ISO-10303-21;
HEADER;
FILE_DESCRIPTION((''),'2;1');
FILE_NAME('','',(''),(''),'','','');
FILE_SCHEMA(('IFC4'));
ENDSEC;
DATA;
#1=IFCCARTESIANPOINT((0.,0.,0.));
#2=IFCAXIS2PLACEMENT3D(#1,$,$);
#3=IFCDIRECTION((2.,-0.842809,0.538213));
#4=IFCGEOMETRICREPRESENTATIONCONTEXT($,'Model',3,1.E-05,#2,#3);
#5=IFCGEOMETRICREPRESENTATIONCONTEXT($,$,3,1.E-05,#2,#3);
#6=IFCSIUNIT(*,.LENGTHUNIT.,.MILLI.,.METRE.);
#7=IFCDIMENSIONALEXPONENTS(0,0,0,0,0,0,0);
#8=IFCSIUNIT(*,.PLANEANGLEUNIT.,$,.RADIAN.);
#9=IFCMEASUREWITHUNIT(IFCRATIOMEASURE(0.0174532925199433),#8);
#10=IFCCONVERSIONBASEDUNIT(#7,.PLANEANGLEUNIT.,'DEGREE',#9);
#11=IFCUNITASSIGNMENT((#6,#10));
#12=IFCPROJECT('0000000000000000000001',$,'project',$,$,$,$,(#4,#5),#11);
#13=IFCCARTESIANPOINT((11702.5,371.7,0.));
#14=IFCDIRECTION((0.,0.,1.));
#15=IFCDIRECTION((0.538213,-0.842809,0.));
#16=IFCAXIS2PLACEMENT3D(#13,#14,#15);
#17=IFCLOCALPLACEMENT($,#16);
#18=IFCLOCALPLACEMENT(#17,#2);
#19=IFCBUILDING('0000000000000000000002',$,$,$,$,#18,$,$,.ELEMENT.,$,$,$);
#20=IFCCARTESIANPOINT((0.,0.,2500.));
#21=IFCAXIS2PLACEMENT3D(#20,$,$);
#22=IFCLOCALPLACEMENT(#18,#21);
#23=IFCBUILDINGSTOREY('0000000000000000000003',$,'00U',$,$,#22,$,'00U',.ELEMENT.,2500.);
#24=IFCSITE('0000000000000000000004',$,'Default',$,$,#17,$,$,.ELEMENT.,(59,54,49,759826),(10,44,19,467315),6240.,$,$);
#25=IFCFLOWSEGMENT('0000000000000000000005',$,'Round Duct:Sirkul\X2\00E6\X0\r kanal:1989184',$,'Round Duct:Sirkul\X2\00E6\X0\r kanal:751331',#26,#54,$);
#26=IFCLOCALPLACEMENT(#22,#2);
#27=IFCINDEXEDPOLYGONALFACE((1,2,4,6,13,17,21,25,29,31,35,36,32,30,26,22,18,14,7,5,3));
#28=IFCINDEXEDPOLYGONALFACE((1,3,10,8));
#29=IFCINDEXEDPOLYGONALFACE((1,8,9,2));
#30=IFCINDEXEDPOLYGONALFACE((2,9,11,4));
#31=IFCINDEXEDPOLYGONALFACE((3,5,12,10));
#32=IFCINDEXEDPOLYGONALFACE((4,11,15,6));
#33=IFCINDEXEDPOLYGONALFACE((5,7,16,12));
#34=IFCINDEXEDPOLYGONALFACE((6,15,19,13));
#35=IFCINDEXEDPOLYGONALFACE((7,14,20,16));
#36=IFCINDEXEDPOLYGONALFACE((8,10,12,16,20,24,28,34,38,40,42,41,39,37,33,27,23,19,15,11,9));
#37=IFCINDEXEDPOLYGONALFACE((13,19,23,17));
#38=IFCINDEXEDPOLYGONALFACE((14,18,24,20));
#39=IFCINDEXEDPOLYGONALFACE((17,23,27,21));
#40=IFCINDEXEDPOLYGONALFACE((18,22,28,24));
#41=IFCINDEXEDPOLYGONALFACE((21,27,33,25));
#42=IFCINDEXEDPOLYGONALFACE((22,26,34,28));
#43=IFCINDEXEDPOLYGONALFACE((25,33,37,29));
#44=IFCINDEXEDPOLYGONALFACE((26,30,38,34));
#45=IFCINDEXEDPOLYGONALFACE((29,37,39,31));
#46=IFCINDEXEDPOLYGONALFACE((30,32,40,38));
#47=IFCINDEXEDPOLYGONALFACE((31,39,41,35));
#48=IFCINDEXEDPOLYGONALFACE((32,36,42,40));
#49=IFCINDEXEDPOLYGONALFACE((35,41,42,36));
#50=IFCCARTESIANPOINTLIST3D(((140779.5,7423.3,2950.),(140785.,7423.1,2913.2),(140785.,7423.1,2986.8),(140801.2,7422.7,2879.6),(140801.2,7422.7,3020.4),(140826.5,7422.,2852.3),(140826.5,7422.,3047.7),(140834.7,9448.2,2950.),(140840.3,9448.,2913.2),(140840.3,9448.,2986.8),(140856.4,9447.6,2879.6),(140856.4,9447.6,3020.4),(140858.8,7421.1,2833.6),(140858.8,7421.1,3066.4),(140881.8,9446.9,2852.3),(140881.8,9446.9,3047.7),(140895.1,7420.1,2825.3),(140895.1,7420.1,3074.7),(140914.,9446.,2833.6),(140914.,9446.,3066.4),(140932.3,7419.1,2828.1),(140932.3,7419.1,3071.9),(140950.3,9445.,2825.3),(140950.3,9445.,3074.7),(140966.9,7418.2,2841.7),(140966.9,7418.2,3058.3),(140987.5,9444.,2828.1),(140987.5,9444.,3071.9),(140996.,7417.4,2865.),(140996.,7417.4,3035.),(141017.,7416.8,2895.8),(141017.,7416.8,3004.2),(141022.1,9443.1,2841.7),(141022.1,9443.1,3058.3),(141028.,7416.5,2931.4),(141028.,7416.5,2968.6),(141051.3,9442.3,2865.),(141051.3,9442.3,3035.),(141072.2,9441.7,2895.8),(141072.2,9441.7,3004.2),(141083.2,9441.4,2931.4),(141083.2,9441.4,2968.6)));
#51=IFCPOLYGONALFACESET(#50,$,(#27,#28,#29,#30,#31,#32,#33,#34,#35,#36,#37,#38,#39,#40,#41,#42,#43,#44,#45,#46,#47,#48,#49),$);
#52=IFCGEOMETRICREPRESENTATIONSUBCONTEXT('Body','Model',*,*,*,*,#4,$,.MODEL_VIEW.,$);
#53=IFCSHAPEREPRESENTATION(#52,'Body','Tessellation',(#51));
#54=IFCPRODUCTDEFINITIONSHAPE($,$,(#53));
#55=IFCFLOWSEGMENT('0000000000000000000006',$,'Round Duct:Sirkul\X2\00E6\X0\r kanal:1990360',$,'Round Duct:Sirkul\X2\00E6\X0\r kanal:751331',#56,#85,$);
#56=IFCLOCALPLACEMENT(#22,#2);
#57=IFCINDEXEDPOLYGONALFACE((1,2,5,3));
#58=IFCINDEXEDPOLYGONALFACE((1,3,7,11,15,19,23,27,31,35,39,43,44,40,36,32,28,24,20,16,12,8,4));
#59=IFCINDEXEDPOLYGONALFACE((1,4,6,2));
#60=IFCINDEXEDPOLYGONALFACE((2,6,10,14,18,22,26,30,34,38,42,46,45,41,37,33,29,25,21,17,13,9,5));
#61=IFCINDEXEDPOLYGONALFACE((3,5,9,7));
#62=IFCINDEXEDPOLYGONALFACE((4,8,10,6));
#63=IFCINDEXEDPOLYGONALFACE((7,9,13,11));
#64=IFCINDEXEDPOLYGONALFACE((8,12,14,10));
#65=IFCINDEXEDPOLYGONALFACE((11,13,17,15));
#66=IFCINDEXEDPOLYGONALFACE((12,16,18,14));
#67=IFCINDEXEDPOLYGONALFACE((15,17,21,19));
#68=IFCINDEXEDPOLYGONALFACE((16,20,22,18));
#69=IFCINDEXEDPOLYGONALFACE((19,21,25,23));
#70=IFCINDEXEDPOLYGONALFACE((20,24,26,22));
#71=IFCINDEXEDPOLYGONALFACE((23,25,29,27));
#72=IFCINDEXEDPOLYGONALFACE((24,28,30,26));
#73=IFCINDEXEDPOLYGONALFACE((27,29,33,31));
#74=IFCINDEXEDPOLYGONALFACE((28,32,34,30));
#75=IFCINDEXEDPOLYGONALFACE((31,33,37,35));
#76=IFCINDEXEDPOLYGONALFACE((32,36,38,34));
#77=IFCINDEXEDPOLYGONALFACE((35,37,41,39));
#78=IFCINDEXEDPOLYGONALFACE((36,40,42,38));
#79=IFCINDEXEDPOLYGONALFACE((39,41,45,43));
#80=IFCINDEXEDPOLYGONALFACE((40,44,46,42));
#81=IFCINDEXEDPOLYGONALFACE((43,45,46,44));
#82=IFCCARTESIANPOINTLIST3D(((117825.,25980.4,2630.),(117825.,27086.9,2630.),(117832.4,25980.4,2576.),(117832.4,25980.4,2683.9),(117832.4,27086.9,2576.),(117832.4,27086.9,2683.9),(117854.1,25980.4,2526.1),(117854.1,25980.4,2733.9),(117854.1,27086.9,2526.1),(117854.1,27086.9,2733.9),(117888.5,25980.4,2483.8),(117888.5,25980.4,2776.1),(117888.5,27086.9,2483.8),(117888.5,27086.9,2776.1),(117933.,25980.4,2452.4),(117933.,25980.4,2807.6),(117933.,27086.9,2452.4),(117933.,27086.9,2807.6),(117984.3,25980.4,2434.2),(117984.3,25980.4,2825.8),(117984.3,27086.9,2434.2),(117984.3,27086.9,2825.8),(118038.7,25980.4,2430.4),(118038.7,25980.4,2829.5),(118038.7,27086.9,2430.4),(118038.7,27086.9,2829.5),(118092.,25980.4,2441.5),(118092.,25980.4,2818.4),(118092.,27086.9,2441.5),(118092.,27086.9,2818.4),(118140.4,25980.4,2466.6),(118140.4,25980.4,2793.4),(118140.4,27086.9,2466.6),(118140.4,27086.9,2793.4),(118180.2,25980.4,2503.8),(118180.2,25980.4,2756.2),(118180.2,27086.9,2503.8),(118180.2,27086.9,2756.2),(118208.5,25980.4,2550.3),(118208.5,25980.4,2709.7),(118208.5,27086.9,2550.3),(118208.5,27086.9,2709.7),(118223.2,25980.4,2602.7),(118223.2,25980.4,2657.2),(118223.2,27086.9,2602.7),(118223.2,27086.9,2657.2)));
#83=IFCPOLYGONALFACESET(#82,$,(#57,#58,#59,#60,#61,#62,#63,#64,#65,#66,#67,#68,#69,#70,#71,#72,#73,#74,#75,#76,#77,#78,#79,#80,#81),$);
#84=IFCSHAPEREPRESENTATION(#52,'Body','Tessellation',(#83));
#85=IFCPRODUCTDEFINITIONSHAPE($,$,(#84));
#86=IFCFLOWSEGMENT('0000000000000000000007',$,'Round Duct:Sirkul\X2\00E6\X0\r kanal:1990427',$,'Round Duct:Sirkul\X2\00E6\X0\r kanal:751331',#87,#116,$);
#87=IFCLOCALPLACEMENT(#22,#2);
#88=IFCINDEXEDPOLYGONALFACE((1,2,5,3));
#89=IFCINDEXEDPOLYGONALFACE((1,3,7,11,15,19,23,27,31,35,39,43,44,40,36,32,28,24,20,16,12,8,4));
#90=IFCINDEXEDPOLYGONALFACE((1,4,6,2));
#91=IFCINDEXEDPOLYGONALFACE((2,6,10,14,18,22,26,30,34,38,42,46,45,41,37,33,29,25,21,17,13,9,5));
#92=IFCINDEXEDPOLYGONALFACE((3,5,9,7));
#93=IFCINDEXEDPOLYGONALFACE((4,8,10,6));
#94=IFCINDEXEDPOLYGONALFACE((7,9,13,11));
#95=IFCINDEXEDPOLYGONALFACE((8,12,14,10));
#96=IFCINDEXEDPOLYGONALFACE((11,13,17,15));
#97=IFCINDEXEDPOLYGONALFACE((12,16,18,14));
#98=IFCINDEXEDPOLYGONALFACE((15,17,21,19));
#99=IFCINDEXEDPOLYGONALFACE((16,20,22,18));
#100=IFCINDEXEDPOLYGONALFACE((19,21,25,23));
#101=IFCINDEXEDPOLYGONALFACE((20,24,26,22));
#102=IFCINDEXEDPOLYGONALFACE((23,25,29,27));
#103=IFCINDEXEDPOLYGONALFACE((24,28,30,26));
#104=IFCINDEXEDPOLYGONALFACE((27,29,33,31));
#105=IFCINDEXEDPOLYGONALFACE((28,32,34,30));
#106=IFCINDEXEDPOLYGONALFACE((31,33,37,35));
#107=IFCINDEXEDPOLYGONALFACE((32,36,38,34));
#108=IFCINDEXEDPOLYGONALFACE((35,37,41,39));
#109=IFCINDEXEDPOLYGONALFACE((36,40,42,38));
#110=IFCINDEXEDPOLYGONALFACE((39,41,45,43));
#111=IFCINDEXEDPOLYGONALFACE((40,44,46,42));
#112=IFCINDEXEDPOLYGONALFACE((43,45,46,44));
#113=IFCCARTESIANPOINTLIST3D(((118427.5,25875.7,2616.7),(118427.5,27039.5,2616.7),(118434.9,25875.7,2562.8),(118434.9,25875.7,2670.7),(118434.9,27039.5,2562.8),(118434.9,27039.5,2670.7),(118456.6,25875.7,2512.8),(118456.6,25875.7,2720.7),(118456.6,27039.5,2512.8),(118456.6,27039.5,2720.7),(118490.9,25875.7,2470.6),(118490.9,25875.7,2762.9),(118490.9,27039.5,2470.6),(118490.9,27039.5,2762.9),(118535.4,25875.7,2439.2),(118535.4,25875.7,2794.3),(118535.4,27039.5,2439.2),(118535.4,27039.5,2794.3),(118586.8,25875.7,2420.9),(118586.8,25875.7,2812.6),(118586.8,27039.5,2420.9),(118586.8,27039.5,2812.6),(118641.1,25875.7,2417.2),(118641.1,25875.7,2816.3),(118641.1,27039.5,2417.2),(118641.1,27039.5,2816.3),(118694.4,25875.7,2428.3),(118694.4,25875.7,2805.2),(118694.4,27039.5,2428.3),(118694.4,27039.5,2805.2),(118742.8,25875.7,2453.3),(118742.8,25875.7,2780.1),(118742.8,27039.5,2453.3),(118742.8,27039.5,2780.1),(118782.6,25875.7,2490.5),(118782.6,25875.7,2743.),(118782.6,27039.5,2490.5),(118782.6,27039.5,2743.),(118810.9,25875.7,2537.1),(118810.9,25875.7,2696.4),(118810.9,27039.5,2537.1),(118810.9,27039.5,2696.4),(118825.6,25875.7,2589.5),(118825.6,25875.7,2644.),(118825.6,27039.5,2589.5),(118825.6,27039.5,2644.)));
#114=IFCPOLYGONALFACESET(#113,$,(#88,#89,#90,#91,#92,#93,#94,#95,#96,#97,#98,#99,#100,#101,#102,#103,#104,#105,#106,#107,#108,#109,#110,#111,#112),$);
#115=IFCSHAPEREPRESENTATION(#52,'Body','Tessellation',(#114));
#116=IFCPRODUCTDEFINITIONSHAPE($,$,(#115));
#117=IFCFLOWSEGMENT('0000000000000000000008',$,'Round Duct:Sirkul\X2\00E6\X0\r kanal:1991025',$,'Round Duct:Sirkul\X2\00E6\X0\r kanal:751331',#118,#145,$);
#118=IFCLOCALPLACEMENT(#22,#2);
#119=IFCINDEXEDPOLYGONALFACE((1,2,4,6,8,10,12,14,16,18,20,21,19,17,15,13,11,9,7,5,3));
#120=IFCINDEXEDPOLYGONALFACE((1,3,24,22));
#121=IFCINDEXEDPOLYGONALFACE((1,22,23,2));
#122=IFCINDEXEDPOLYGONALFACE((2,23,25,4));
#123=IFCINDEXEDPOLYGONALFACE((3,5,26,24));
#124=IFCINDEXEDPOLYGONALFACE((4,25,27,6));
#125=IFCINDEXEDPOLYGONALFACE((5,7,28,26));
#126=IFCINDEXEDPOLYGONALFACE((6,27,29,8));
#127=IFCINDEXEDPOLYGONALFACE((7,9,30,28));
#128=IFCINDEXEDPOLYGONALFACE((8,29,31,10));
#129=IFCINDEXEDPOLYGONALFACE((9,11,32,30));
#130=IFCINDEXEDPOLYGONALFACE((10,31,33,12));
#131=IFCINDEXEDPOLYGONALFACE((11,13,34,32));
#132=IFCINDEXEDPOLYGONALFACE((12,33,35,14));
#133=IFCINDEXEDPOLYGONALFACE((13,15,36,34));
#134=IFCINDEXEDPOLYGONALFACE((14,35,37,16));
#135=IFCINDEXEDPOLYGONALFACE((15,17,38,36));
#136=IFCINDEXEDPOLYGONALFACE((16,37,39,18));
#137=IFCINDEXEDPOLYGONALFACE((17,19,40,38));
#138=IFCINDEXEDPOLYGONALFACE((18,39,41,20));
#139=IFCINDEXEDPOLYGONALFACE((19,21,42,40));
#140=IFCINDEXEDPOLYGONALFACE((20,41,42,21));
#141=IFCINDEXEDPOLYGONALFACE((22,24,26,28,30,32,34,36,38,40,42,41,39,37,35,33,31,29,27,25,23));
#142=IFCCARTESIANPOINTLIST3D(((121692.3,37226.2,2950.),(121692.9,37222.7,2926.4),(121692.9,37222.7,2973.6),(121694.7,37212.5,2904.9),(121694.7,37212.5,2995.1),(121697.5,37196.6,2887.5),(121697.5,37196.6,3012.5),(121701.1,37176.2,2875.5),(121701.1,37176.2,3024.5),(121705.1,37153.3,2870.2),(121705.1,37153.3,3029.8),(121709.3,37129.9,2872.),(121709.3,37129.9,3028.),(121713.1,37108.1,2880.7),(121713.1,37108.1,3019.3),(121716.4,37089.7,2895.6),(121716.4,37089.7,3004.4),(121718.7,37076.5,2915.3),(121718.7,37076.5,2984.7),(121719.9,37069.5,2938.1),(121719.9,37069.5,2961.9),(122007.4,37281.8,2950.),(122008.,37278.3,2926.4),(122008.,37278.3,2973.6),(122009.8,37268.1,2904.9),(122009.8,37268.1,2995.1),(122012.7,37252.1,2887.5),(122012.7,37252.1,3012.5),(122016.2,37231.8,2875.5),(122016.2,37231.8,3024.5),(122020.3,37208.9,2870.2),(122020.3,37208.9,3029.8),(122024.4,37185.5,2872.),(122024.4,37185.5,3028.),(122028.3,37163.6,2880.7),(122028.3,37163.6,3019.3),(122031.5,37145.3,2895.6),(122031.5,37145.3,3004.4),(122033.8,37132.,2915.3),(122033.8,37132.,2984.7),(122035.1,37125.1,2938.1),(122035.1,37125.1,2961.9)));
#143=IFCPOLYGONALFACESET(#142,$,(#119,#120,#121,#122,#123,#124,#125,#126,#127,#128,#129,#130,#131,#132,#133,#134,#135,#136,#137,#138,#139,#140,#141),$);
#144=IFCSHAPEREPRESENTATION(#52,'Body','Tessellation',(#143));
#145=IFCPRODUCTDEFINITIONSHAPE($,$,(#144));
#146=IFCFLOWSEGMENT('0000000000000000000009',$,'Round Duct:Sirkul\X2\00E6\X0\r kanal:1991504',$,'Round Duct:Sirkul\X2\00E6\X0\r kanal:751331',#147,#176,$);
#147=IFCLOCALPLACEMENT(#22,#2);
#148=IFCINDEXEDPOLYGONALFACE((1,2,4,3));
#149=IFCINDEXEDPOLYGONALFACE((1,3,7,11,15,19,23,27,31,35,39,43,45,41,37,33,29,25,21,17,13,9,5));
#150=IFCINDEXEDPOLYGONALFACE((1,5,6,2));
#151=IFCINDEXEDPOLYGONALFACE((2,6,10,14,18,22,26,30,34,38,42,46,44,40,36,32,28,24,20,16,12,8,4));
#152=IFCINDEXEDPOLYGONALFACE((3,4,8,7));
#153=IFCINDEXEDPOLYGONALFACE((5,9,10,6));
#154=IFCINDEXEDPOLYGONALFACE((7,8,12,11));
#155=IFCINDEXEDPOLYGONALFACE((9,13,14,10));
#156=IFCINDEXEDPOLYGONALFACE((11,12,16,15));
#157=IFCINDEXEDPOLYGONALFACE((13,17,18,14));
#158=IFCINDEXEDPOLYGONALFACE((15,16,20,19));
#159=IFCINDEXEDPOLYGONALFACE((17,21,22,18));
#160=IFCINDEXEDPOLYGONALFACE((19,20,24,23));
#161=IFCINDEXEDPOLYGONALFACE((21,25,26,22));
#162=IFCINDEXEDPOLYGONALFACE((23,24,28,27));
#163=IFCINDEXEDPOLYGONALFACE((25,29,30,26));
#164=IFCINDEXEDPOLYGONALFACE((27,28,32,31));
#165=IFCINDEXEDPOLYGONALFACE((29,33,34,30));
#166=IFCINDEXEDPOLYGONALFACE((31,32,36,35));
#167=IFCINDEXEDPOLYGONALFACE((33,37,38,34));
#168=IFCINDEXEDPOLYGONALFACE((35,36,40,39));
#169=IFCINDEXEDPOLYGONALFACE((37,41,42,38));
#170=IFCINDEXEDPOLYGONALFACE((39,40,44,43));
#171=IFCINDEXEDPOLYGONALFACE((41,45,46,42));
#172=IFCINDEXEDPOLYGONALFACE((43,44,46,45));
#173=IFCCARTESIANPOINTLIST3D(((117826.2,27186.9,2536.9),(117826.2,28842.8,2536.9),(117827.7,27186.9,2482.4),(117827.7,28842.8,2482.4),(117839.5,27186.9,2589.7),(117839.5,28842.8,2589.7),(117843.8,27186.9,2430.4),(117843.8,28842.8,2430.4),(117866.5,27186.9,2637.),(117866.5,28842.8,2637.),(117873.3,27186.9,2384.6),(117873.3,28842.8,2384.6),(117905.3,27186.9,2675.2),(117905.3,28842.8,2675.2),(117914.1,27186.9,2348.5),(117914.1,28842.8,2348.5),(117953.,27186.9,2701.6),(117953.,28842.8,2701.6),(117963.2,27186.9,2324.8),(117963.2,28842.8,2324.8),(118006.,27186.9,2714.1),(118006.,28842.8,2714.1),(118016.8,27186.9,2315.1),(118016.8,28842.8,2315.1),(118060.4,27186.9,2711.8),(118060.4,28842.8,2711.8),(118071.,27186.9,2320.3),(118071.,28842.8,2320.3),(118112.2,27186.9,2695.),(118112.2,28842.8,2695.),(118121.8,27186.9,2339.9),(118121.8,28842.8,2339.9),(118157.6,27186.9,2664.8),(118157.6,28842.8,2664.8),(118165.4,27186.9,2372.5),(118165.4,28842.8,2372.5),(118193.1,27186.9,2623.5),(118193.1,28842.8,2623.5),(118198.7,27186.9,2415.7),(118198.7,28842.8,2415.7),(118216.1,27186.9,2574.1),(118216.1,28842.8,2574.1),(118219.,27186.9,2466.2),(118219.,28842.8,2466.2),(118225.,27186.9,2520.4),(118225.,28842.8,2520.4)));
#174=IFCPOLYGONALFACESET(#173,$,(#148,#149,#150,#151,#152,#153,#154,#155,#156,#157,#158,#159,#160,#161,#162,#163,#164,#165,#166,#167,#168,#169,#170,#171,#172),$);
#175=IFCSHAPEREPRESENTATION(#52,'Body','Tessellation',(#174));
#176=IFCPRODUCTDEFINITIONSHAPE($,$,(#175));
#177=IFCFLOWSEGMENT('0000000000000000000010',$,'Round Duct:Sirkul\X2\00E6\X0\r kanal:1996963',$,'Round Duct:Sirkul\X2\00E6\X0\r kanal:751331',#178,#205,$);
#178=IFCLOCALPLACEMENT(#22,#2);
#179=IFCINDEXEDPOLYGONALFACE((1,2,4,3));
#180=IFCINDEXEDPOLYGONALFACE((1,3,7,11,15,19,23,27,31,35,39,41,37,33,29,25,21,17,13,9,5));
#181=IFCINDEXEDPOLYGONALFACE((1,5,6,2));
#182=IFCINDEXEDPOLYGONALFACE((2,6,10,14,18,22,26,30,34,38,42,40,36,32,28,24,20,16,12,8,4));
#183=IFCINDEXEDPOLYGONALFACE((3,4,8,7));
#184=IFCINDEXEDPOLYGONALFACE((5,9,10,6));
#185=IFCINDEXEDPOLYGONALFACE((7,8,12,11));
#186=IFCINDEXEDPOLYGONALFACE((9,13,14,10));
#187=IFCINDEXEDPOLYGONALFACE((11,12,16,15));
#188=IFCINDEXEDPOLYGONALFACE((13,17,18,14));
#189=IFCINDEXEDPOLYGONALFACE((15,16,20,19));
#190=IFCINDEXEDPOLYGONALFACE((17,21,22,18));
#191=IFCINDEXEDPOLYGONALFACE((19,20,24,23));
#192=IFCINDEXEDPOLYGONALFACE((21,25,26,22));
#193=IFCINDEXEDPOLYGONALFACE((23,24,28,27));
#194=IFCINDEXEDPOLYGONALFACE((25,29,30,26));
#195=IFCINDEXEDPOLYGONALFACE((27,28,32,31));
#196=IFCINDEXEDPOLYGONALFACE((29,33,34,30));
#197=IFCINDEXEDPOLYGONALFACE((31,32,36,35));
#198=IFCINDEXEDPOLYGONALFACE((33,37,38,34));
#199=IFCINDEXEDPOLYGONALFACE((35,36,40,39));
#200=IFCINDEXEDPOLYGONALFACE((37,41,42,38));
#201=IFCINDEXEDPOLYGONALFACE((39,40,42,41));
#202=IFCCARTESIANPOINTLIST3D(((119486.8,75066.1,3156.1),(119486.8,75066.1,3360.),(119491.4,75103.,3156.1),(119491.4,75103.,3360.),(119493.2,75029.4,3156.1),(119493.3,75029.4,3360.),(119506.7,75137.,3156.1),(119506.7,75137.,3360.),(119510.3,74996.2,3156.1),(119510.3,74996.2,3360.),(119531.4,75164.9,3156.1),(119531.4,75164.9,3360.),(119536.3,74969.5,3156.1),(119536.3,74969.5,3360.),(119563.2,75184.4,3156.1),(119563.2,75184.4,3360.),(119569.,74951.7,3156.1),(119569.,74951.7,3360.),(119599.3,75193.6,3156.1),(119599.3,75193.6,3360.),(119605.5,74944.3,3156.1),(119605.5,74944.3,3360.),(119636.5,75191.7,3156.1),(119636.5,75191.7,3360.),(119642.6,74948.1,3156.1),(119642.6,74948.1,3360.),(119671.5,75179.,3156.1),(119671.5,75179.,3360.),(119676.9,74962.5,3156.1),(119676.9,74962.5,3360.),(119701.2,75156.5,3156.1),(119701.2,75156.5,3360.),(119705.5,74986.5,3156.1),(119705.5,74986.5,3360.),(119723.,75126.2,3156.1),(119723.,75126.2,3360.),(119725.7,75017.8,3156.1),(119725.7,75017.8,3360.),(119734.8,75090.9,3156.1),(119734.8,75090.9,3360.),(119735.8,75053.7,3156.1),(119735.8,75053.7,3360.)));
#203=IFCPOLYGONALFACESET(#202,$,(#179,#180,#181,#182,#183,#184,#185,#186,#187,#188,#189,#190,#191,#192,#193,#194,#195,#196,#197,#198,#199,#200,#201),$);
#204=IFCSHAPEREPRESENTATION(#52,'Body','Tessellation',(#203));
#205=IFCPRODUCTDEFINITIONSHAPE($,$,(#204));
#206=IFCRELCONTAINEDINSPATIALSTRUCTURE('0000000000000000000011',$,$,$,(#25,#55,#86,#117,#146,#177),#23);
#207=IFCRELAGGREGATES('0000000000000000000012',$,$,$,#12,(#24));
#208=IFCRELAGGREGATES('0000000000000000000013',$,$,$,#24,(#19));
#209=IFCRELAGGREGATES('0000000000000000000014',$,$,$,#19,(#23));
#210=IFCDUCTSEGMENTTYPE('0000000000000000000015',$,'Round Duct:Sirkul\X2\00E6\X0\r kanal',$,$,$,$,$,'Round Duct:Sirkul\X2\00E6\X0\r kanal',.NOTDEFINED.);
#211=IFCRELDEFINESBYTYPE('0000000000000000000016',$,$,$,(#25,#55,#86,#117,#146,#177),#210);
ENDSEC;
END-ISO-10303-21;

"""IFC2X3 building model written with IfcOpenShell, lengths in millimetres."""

from ifc_helpers import new_model, entity, si_unit, converted_unit, direction, frame, origin, origin_2d_with_axis, place, context, subcontext, project, spatial, circle, extrude, type_object, element, save


model = new_model("IFC2X3")

# Units and contexts
model_context = context("Model", 3, precision=1e-05, world=origin(), true_north=direction((2.0, -0.842809, 0.538213)))
context_of_model = context(None, 3, precision=1e-05, world=origin(), true_north=direction((2.0, -0.842809, 0.538213)))
body_context = subcontext(model_context, "Body", "Model", "MODEL_VIEW")
ifc_project = project(units=[si_unit("LENGTHUNIT", "METRE", prefix="MILLI"), converted_unit("PLANEANGLEUNIT", "DEGREE", entity("IfcRatioMeasure", 0.0174532925199433), si_unit("PLANEANGLEUNIT", "RADIAN"), dimensions=[0, 0, 0, 0, 0, 0, 0])], contexts=[model_context, context_of_model])

# Site, building, storey
site_placement = place(None, frame((11702.5, 371.7, 0.0), z_axis=(0.0, 0.0, 1.0), x_axis=(0.538213, -0.842809, 0.0)))
site = spatial("IfcSite", under=ifc_project, at=site_placement, Name="Default", CompositionType="ELEMENT", RefLatitude=(59, 54, 49, 759826), RefLongitude=(10, 44, 19, 467315), RefElevation=6240.0)
building_placement = place(site_placement, origin())
building = spatial("IfcBuilding", under=site, at=building_placement, CompositionType="ELEMENT")
storey_placement = place(building_placement, frame((0.0, 0.0, 2500.0)))
storey = spatial("IfcBuildingStorey", under=building, at=storey_placement, Name="00U", LongName="00U", CompositionType="ELEMENT", Elevation=2500.0)

# Flow segments
duct_segment_type_1 = type_object("IfcDuctSegmentType", Name="Round Duct:Sirkulær kanal", ElementType="Round Duct:Sirkulær kanal", PredefinedType="NOTDEFINED")
flow_segment_1_placement = place(storey_placement, origin())
element("IfcFlowSegment", 1, at=flow_segment_1_placement, inside=storey, type_object=duct_segment_type_1, Name="Round Duct:Sirkulær kanal:1989184", ObjectType="Round Duct:Sirkulær kanal:751331", context=body_context, shape_type="SweptSolid", body=[
    extrude(circle(Radius=125.0, at=origin_2d_with_axis()), frame((140904.5, 7419.9, 2950.0), z_axis=(0.02726, 0.999628, 0.0), x_axis=(-0.999628, 0.02726, 0.0)), (0.0, 0.0, 1.0), 2025.6),
])
flow_segment_2_placement = place(storey_placement, origin())
element("IfcFlowSegment", 2, at=flow_segment_2_placement, inside=storey, type_object=duct_segment_type_1, Name="Round Duct:Sirkulær kanal:1990360", ObjectType="Round Duct:Sirkulær kanal:751331", context=body_context, shape_type="SweptSolid", body=[
    extrude(circle(Radius=200.0, at=origin_2d_with_axis()), frame((118025.0, 25980.4, 2630.0), z_axis=(0.0, 1.0, 0.0), x_axis=(-1.0, 0.0, 0.0)), (0.0, 0.0, 1.0), 1106.5),
])
flow_segment_3_placement = place(storey_placement, origin())
element("IfcFlowSegment", 3, at=flow_segment_3_placement, inside=storey, type_object=duct_segment_type_1, Name="Round Duct:Sirkulær kanal:1990427", ObjectType="Round Duct:Sirkulær kanal:751331", context=body_context, shape_type="SweptSolid", body=[
    extrude(circle(Radius=200.0, at=origin_2d_with_axis()), frame((118627.5, 25875.7, 2616.7), z_axis=(0.0, 1.0, 0.0), x_axis=(-1.0, 0.0, 0.0)), (0.0, 0.0, 1.0), 1163.7),
])
flow_segment_4_placement = place(storey_placement, origin())
element("IfcFlowSegment", 4, at=flow_segment_4_placement, inside=storey, type_object=duct_segment_type_1, Name="Round Duct:Sirkulær kanal:1991025", ObjectType="Round Duct:Sirkulær kanal:751331", context=body_context, shape_type="SweptSolid", body=[
    extrude(circle(Radius=80.0, at=origin_2d_with_axis()), frame((121706.2, 37147.4, 2950.0), z_axis=(0.984808, 0.173648, 0.0), x_axis=(-0.173648, 0.984808, 0.0)), (0.0, 0.0, 1.0), 320.0),
])
flow_segment_5_placement = place(storey_placement, origin())
element("IfcFlowSegment", 5, at=flow_segment_5_placement, inside=storey, type_object=duct_segment_type_1, Name="Round Duct:Sirkulær kanal:1991504", ObjectType="Round Duct:Sirkulær kanal:751331", context=body_context, shape_type="SweptSolid", body=[
    extrude(circle(Radius=200.0, at=origin_2d_with_axis()), frame((118025.0, 27186.9, 2515.0), z_axis=(0.0, 1.0, 0.0), x_axis=(0.999637, 0.0, 0.026944)), (0.0, 0.0, 1.0), 1655.9),
])
flow_segment_6_placement = place(storey_placement, origin())
element("IfcFlowSegment", 6, at=flow_segment_6_placement, inside=storey, type_object=duct_segment_type_1, Name="Round Duct:Sirkulær kanal:1996963", ObjectType="Round Duct:Sirkulær kanal:751331", context=body_context, shape_type="SweptSolid", body=[
    extrude(circle(Radius=125.0, at=origin_2d_with_axis()), frame((119611.7, 75069.2, 3156.1), z_axis=(0.000001, -0.000002, 1.0), x_axis=(0.521574, -0.853206, -0.000002)), (0.0, 0.0, 1.0), 203.9),
])

save(model, "model.ifc")
